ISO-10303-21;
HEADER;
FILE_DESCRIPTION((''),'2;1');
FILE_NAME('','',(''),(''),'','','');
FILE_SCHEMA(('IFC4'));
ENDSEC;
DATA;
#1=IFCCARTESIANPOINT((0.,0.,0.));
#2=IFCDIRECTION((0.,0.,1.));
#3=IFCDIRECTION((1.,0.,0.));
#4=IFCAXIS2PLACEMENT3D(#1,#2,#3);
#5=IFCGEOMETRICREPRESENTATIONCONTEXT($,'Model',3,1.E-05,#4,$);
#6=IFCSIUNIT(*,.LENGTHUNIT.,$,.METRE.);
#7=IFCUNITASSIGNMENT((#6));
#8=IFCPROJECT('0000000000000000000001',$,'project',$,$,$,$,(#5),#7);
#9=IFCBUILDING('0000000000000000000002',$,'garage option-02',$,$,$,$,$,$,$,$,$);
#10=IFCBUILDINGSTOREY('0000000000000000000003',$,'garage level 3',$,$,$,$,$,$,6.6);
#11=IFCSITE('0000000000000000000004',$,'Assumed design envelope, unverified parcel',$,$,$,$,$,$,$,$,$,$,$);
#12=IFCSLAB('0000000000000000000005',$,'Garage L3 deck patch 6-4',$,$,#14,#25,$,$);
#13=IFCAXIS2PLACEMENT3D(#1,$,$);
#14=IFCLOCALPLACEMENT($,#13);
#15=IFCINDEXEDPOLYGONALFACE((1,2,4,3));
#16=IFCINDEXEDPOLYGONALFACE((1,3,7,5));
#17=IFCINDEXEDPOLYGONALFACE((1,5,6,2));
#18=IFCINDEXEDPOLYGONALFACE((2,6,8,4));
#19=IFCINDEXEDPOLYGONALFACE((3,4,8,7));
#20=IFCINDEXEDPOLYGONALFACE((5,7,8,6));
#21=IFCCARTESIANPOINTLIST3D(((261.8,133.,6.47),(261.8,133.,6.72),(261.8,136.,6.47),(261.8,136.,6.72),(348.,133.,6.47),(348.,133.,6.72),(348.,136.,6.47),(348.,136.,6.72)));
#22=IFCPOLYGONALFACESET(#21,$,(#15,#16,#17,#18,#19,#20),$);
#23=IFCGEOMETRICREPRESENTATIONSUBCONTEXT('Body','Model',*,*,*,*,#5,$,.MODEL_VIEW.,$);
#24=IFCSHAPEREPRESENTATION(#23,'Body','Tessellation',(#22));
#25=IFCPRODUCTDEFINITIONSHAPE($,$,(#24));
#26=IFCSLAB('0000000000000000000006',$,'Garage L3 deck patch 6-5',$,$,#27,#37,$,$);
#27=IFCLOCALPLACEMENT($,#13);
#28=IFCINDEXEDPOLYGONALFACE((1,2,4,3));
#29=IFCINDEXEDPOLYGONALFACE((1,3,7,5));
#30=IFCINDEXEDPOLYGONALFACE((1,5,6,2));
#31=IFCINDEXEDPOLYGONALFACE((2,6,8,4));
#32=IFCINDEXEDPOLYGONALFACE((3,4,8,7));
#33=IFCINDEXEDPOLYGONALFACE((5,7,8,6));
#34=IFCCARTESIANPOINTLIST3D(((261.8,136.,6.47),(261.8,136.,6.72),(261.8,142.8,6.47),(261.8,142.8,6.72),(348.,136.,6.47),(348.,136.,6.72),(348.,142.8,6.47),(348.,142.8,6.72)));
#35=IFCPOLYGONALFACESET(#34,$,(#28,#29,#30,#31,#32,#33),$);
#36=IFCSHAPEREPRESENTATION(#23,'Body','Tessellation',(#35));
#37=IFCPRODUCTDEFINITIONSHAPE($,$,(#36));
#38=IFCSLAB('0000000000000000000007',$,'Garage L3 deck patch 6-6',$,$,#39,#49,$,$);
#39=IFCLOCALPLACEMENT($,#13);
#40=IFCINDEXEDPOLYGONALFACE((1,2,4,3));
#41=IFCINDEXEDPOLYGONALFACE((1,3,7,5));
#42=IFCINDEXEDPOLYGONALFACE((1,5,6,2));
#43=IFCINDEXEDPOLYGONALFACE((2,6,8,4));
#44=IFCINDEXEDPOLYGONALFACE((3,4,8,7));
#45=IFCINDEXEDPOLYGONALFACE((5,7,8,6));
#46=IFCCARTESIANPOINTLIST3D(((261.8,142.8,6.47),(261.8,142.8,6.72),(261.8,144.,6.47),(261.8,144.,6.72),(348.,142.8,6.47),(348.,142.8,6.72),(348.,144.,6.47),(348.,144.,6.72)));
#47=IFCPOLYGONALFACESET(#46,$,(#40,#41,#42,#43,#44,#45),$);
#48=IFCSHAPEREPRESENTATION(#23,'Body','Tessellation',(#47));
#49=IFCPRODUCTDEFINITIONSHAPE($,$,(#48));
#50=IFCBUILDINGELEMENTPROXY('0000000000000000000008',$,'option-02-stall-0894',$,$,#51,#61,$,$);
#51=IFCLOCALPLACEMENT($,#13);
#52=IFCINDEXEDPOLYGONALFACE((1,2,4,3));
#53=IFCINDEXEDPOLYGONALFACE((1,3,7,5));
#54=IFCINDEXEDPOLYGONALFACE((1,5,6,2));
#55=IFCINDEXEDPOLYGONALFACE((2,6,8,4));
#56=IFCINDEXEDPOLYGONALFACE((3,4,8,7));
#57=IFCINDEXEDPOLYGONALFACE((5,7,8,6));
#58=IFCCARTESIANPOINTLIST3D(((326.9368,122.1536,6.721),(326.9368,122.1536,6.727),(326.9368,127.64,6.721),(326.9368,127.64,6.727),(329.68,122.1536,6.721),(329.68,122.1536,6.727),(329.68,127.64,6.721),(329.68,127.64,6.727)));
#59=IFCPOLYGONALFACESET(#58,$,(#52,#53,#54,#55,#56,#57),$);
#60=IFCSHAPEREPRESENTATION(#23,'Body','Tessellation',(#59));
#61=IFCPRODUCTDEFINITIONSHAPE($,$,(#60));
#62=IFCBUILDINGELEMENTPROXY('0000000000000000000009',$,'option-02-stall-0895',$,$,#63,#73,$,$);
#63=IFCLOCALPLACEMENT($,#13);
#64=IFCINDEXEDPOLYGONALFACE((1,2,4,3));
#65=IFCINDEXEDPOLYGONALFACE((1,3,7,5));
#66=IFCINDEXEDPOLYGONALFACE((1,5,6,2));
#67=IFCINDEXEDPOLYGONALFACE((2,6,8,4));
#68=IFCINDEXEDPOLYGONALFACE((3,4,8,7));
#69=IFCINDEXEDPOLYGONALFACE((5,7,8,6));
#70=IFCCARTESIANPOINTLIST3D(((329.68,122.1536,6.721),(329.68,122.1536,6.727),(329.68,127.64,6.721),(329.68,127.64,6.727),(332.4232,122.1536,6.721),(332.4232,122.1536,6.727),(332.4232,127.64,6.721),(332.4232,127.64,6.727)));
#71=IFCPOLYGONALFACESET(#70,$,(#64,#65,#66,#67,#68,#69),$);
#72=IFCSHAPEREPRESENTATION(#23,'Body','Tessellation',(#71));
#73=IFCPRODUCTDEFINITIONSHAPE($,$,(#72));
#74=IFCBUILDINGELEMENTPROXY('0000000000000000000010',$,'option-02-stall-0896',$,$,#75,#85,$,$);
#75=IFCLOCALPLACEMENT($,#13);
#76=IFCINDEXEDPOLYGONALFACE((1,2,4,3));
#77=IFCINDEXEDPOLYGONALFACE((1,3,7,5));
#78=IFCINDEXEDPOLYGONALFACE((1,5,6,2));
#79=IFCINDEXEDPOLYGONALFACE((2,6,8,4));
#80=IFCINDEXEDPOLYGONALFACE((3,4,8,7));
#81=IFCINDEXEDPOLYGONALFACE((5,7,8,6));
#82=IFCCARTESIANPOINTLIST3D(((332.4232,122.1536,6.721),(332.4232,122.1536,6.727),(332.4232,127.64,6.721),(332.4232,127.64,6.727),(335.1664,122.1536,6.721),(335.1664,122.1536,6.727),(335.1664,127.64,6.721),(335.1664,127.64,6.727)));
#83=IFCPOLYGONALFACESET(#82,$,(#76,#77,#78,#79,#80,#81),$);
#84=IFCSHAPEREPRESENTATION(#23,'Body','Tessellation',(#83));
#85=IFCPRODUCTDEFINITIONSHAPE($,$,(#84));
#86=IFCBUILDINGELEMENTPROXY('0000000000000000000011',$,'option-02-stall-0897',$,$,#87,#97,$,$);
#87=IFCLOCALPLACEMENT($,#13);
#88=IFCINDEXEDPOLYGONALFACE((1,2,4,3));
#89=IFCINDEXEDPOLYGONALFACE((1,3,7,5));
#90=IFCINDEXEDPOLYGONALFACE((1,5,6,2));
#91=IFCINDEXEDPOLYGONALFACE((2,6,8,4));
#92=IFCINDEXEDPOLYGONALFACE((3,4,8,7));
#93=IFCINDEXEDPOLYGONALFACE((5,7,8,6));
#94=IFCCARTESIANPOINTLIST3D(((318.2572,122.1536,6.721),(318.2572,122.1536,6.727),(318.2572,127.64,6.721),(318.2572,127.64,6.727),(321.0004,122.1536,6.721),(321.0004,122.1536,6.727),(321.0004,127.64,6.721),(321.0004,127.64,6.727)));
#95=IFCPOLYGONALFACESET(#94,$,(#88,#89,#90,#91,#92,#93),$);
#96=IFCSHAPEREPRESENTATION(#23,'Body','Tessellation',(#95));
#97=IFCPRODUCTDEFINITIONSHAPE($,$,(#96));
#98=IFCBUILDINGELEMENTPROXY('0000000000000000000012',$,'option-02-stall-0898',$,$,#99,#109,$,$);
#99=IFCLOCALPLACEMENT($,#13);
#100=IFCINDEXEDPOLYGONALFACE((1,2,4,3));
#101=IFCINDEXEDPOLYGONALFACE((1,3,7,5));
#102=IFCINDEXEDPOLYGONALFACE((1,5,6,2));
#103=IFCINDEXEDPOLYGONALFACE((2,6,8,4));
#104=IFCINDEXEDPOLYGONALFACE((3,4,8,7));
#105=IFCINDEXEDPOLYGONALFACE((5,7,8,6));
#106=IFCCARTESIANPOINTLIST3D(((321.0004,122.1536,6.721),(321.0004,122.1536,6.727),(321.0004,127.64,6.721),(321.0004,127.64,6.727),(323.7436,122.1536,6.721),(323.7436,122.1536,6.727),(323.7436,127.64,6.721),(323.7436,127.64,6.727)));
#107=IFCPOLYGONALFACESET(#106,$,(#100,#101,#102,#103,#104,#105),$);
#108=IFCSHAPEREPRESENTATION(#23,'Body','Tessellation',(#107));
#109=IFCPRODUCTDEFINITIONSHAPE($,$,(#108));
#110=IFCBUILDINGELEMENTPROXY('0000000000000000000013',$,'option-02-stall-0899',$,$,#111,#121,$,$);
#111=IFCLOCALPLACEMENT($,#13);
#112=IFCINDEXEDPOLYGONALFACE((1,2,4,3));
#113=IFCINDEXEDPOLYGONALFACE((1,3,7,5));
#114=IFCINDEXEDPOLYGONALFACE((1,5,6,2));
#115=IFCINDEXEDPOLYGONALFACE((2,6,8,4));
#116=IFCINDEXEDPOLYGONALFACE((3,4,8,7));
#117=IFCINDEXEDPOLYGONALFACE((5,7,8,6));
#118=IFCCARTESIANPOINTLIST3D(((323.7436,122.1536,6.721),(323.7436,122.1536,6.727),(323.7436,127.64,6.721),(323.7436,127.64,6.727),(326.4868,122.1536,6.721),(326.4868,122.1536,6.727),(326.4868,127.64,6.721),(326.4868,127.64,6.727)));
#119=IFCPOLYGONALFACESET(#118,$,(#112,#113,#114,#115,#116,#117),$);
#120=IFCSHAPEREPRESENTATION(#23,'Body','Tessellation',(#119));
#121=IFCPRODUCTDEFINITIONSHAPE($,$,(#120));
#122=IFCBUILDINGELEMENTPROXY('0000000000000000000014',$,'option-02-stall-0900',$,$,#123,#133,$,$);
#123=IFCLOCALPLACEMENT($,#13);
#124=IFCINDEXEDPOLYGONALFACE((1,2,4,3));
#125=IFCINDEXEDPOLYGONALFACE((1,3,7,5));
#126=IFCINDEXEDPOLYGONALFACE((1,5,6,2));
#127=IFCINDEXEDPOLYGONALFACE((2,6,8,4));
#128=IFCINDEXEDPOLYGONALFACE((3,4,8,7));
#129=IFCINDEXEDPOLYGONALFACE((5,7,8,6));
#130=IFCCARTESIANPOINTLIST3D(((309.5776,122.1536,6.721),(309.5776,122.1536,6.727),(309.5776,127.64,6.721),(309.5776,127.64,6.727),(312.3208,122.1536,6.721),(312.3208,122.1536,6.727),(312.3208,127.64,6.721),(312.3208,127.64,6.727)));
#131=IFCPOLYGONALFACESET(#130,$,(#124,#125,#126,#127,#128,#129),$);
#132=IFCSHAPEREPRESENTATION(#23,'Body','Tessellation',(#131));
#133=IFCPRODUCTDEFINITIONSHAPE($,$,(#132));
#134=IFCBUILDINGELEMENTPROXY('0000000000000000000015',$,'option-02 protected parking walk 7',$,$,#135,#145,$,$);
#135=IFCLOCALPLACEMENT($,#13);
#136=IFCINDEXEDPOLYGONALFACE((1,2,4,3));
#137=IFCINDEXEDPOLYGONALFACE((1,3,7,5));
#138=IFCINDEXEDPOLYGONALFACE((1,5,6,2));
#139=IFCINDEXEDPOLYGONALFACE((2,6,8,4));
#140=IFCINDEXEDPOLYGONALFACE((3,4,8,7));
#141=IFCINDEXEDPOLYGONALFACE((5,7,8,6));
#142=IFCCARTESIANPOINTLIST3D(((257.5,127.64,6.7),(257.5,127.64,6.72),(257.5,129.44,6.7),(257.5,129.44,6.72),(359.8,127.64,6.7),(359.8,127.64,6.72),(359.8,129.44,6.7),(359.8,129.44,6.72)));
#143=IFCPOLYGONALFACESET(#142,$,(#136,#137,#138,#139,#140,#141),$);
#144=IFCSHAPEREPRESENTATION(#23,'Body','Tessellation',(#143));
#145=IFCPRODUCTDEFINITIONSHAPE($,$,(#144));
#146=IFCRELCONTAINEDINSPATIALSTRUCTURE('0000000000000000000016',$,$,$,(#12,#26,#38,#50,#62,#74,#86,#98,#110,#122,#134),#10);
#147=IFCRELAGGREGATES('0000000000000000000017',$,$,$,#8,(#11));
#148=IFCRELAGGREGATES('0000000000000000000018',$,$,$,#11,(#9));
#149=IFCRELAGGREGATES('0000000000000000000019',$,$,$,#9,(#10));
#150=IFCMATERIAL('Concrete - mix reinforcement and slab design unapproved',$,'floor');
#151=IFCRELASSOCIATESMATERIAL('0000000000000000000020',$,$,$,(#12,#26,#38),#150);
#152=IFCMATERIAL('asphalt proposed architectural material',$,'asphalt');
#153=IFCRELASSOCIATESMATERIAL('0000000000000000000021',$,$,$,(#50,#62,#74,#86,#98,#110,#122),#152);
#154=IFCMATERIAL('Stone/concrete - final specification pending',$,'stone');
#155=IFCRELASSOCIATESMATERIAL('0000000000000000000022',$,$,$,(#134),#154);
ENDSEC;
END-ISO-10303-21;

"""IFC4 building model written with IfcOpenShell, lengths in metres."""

from ifc_helpers import new_model, si_unit, frame, origin_with_axes, place, context, subcontext, project, spatial, rectangle, extrude, material, element, save


model = new_model("IFC4")

# Units and contexts
model_context = context("Model", 3, precision=1e-05, world=origin_with_axes())
body_context = subcontext(model_context, "Body", "Model", "MODEL_VIEW")
ifc_project = project(units=[si_unit("LENGTHUNIT", "METRE")], contexts=[model_context])

# Site, building, storey
site = spatial("IfcSite", under=ifc_project, Name="Assumed design envelope, unverified parcel")
building = spatial("IfcBuilding", under=site, Name="garage option-02")
storey = spatial("IfcBuildingStorey", under=building, Name="garage level 3", Elevation=6.6)

# Shared definitions
ifc_material_1 = material(Name="Concrete - mix reinforcement and slab design unapproved", Category="floor")

# Slabs
for number, where, z_axis, x_axis, name in (
    (1, (304.9, 134.5, 6.47), (0.0, 0.0, 1.0), (1.0, 0.0, 0.0), "Garage L3 deck patch 6-4"),
):
    element("IfcSlab", number, at=place(None, frame(where, z_axis=z_axis, x_axis=x_axis)), inside=storey, material=ifc_material_1, Name=name, context=body_context, shape_type="SweptSolid", body=[
        extrude(rectangle(XDim=86.2, YDim=3.0), origin_with_axes(), (0.0, 0.0, 1.0), 0.25),
    ])
slab_1_placement = place(None, frame((304.9, 139.4, 6.47), z_axis=(0.0, 0.0, 1.0), x_axis=(1.0, 0.0, 0.0)))
element("IfcSlab", 2, at=slab_1_placement, inside=storey, material=ifc_material_1, Name="Garage L3 deck patch 6-5", context=body_context, shape_type="SweptSolid", body=[
    extrude(rectangle(XDim=86.2, YDim=6.8), origin_with_axes(), (0.0, 0.0, 1.0), 0.25),
])
slab_2_placement = place(None, frame((304.9, 143.4, 6.47), z_axis=(0.0, 0.0, 1.0), x_axis=(1.0, 0.0, 0.0)))
element("IfcSlab", 3, at=slab_2_placement, inside=storey, material=ifc_material_1, Name="Garage L3 deck patch 6-6", context=body_context, shape_type="SweptSolid", body=[
    extrude(rectangle(XDim=86.2, YDim=1.2), origin_with_axes(), (0.0, 0.0, 1.0), 0.25),
])

# Building element proxies
ifc_material_2 = material(Name="asphalt proposed architectural material", Category="asphalt")
for number, where, z_axis, x_axis, name in (
    (4, (328.3084, 124.8968, 6.721), (0.0, 0.0, 1.0), (1.0, 0.0, 0.0), "option-02-stall-0894"),
    (5, (331.0516, 124.8968, 6.721), (0.0, 0.0, 1.0), (1.0, 0.0, 0.0), "option-02-stall-0895"),
    (6, (333.7948, 124.8968, 6.721), (0.0, 0.0, 1.0), (1.0, 0.0, 0.0), "option-02-stall-0896"),
    (7, (319.6288, 124.8968, 6.721), (0.0, 0.0, 1.0), (1.0, 0.0, 0.0), "option-02-stall-0897"),
    (8, (322.372, 124.8968, 6.721), (0.0, 0.0, 1.0), (1.0, 0.0, 0.0), "option-02-stall-0898"),
    (9, (325.1152, 124.8968, 6.721), (0.0, 0.0, 1.0), (1.0, 0.0, 0.0), "option-02-stall-0899"),
    (10, (310.9492, 124.8968, 6.721), (0.0, 0.0, 1.0), (1.0, 0.0, 0.0), "option-02-stall-0900"),
):
    element("IfcBuildingElementProxy", number, at=place(None, frame(where, z_axis=z_axis, x_axis=x_axis)), inside=storey, material=ifc_material_2, Name=name, context=body_context, shape_type="SweptSolid", body=[
        extrude(rectangle(XDim=2.7432, YDim=5.4864), origin_with_axes(), (0.0, 0.0, 1.0), 0.006),
    ])
ifc_material_3 = material(Name="Stone/concrete - final specification pending", Category="stone")
proxy_placement = place(None, frame((308.65, 128.54, 6.7), z_axis=(0.0, 0.0, 1.0), x_axis=(1.0, 0.0, 0.0)))
element("IfcBuildingElementProxy", 11, at=proxy_placement, inside=storey, material=ifc_material_3, Name="option-02 protected parking walk 7", context=body_context, shape_type="SweptSolid", body=[
    extrude(rectangle(XDim=102.3, YDim=1.8), origin_with_axes(), (0.0, 0.0, 1.0), 0.02),
])

save(model, "model.ifc")
